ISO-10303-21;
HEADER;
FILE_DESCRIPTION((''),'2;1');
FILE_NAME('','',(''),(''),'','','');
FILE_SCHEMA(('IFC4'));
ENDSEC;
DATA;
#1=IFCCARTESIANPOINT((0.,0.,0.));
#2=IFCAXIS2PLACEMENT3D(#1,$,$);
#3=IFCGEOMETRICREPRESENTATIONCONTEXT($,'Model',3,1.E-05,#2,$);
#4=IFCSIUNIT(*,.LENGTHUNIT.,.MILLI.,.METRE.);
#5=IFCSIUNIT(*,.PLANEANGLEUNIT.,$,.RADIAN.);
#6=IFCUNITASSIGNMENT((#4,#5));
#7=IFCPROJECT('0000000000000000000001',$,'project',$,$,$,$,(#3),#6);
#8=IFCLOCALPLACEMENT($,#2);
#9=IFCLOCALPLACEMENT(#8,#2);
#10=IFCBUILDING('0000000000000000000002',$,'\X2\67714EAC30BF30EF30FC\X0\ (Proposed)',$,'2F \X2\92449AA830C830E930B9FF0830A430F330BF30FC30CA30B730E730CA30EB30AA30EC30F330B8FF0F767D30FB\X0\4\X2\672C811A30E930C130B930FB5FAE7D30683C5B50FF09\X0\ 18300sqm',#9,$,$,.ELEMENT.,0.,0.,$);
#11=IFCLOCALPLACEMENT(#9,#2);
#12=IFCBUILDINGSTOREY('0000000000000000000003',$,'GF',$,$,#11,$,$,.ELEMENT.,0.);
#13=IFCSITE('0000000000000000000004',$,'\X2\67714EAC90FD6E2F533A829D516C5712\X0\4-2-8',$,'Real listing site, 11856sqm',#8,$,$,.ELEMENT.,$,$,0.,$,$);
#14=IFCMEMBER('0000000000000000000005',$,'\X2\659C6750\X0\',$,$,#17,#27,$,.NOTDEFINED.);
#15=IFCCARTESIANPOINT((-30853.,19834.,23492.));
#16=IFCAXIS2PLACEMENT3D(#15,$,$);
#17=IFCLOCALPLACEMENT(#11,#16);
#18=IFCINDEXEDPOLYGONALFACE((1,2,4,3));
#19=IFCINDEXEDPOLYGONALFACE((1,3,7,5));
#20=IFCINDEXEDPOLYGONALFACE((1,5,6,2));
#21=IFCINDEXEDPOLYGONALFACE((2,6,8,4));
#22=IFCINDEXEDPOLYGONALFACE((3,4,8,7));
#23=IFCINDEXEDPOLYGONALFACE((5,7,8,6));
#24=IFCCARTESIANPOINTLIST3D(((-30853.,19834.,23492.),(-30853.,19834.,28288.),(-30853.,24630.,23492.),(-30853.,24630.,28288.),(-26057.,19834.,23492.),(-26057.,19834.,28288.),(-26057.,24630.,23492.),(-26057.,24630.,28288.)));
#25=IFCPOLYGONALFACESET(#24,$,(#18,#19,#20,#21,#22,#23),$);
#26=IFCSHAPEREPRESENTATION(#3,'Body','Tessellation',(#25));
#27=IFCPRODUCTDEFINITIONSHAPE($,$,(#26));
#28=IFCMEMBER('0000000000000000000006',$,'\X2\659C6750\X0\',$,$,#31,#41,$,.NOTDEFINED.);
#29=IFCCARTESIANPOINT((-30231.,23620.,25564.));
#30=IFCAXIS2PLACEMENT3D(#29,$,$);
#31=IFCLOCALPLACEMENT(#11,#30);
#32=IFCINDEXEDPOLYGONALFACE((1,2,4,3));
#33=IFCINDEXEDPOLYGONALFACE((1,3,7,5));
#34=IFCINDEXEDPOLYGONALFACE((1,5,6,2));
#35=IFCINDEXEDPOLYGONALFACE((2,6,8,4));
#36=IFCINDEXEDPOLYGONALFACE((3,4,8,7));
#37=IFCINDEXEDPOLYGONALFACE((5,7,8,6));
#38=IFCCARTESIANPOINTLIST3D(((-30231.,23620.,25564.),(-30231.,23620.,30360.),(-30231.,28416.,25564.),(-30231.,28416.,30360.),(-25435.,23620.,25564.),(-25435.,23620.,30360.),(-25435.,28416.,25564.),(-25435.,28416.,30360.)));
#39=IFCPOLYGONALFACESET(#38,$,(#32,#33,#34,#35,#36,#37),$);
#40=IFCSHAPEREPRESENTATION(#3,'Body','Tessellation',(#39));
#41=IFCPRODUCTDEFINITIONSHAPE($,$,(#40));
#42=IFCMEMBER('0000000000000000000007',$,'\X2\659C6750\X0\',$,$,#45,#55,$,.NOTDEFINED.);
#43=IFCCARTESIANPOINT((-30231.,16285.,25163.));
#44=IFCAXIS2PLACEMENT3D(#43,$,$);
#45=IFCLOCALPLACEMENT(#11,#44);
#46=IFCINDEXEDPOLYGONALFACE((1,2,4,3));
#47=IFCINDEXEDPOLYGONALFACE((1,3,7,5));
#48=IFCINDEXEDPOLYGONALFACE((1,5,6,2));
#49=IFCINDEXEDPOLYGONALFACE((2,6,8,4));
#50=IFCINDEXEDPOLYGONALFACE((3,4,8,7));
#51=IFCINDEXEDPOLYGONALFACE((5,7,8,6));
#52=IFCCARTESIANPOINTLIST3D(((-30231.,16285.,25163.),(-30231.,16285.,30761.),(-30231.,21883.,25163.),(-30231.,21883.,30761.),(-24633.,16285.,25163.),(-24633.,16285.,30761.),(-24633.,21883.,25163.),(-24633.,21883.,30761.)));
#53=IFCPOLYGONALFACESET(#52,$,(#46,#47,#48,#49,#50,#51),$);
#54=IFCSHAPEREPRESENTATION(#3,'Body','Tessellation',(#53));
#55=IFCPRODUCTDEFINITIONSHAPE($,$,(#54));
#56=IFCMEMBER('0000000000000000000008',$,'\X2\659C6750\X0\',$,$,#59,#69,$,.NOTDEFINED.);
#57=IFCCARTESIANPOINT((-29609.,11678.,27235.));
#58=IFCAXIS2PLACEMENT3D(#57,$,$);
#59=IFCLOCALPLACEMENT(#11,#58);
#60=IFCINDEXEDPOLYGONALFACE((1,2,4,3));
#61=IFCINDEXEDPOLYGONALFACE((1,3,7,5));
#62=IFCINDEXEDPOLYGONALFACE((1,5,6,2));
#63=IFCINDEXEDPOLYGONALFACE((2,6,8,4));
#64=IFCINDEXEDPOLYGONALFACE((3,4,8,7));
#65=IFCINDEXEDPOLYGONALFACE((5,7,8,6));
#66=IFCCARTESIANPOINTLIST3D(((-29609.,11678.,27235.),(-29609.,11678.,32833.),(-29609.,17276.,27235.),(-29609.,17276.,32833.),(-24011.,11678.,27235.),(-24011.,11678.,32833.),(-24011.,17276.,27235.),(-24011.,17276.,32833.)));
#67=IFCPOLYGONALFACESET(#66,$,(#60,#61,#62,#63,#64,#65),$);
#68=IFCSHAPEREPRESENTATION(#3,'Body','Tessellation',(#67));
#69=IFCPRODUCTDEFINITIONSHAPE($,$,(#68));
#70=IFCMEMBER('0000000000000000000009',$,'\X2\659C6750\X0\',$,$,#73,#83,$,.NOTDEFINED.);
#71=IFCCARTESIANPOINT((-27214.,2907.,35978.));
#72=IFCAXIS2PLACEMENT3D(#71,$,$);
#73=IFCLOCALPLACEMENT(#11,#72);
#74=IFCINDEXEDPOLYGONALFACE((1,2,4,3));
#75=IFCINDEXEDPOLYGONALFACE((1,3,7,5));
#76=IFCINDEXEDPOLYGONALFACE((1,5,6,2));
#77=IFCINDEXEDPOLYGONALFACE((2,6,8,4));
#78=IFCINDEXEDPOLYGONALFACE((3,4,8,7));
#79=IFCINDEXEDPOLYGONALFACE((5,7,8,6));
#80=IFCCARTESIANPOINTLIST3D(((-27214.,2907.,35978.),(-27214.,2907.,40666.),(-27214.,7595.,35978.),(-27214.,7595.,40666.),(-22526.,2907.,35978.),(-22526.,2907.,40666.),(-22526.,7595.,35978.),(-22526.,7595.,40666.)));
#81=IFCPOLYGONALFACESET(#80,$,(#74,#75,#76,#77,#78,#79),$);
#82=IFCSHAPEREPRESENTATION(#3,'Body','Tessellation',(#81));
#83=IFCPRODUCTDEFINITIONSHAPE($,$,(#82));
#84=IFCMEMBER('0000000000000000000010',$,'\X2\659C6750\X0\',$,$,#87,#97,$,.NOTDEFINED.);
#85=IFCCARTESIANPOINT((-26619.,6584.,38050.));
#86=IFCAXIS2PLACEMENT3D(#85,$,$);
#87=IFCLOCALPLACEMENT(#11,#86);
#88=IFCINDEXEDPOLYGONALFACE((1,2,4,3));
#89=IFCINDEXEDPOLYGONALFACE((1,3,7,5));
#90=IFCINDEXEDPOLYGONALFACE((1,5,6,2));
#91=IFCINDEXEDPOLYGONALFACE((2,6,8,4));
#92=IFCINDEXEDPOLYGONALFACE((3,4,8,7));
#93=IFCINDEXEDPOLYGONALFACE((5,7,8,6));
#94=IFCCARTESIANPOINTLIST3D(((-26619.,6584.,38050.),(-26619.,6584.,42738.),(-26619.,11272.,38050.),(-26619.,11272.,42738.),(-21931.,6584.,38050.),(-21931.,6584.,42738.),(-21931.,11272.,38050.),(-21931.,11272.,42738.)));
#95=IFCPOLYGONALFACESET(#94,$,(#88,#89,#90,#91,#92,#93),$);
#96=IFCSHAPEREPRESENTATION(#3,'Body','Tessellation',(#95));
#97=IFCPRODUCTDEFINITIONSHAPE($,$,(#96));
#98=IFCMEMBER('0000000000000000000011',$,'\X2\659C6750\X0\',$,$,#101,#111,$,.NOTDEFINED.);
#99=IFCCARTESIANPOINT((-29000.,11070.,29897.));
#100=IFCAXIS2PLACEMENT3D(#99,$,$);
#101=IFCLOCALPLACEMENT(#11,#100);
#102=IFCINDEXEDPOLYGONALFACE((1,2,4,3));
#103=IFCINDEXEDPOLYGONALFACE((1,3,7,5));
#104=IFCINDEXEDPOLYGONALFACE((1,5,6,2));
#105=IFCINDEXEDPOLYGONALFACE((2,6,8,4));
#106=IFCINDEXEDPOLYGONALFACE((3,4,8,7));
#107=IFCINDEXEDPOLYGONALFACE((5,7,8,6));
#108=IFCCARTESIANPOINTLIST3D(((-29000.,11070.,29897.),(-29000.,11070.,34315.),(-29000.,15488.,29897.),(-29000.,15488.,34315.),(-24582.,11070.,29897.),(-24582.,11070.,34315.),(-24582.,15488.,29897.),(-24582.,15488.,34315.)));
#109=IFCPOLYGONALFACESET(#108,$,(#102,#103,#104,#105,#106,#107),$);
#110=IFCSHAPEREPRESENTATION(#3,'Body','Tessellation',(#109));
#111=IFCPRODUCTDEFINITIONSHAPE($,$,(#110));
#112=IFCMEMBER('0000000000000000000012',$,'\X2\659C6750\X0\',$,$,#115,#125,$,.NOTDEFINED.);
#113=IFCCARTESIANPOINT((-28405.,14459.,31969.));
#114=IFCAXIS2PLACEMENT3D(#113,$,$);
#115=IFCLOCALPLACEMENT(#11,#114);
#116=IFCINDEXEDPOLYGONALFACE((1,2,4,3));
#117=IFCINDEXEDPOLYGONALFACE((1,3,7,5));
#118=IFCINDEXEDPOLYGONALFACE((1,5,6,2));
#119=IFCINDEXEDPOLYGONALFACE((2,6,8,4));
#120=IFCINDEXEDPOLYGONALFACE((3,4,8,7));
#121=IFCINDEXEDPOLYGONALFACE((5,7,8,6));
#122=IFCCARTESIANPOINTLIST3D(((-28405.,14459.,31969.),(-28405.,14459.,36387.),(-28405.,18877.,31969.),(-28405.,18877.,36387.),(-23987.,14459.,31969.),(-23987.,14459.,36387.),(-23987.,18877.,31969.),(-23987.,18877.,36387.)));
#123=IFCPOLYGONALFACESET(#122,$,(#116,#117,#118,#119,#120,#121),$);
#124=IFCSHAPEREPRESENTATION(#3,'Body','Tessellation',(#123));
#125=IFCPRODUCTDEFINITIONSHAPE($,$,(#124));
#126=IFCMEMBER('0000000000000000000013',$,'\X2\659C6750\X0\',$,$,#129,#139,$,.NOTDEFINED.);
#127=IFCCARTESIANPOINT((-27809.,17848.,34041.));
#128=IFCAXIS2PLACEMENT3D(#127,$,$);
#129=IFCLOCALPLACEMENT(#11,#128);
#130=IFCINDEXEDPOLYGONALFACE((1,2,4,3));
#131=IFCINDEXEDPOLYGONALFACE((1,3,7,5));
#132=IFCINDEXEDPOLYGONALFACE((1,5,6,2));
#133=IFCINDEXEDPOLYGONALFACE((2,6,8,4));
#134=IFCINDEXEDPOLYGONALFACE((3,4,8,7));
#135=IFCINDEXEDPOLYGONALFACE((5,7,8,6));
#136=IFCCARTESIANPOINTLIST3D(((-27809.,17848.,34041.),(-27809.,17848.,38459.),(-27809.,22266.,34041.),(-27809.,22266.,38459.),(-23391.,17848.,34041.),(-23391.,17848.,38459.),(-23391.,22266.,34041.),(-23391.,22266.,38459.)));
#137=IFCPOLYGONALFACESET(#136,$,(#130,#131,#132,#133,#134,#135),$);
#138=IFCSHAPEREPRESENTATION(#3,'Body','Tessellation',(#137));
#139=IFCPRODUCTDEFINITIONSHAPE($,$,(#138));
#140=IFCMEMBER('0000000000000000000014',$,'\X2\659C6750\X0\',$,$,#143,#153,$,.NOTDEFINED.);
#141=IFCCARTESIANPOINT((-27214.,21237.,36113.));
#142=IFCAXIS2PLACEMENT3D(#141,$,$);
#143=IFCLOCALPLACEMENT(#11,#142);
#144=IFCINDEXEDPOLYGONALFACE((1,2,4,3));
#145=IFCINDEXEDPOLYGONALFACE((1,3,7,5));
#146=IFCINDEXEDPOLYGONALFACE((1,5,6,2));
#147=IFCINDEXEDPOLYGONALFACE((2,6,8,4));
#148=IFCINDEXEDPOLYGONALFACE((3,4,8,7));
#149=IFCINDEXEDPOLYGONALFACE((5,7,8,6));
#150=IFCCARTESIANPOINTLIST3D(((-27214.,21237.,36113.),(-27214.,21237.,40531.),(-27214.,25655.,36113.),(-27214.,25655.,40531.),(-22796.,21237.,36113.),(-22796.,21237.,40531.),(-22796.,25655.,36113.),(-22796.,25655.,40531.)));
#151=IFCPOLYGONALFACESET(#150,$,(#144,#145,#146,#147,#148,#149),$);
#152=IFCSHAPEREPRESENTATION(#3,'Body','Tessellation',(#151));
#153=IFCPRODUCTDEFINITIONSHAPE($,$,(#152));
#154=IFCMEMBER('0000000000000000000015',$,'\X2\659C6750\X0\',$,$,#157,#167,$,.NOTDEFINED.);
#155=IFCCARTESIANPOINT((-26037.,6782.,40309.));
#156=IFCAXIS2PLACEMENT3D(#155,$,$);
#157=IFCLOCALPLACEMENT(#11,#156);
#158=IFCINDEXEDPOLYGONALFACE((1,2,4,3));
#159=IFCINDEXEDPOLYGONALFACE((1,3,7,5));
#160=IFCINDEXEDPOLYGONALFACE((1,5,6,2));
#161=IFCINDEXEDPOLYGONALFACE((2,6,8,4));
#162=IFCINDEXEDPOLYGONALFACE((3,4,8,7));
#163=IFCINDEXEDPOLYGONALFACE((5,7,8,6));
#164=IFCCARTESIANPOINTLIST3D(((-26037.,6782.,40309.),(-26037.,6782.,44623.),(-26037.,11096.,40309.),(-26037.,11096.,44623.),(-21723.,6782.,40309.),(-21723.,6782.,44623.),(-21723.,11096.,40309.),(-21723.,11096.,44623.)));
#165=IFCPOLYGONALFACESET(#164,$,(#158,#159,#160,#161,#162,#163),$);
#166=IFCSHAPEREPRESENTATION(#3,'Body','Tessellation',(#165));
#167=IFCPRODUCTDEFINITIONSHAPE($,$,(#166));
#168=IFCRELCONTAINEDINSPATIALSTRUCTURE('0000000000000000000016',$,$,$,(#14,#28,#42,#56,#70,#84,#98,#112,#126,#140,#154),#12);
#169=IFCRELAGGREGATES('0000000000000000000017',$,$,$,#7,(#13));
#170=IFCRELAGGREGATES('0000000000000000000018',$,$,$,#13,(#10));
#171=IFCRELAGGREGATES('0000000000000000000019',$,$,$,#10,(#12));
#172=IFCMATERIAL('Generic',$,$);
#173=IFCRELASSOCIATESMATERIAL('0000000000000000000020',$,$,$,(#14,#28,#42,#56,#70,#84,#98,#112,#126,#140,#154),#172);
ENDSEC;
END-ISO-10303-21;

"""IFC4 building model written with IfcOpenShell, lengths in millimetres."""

from ifc_helpers import new_model, si_unit, frame, frame_2d, origin, place, context, project, spatial, rectangle, extrude, material, element, save


model = new_model("IFC4")

# Units and contexts
model_context = context("Model", 3, precision=1e-05, world=origin())
ifc_project = project(units=[si_unit("LENGTHUNIT", "METRE", prefix="MILLI"), si_unit("PLANEANGLEUNIT", "RADIAN")], contexts=[model_context])

# Site, building, storey
site_placement = place(None, origin())
site = spatial("IfcSite", under=ifc_project, at=site_placement, Name="東京都港区芝公園4-2-8", ObjectType="Real listing site, 11856sqm", CompositionType="ELEMENT", RefElevation=0.0)
building_placement = place(site_placement, origin())
building = spatial("IfcBuilding", under=site, at=building_placement, Name="東京タワー (Proposed)", ObjectType="2F 鉄骨トラス（インターナショナルオレンジ／白・4本脚ラチス・微細格子） 18300sqm", CompositionType="ELEMENT", ElevationOfRefHeight=0.0, ElevationOfTerrain=0.0)
storey_placement = place(building_placement, origin())
storey = spatial("IfcBuildingStorey", under=building, at=storey_placement, Name="GF", CompositionType="ELEMENT", Elevation=0.0)

# Shared definitions
ifc_material = material(Name="Generic")

# Members
member_1_placement = place(storey_placement, frame((-30853.0, 19834.0, 23492.0)))
element("IfcMember", 1, at=member_1_placement, inside=storey, material=ifc_material, Name="斜材", PredefinedType="NOTDEFINED", context=model_context, shape_type="SweptSolid", body=[
    extrude(rectangle(XDim=4796.0, YDim=4796.0, at=frame_2d((2398.0, 2398.0))), frame((-30853.0, 19834.0, 23492.0)), (0.0, 0.0, 1.0), 4796.0),
])
member_2_placement = place(storey_placement, frame((-30231.0, 23620.0, 25564.0)))
element("IfcMember", 2, at=member_2_placement, inside=storey, material=ifc_material, Name="斜材", PredefinedType="NOTDEFINED", context=model_context, shape_type="SweptSolid", body=[
    extrude(rectangle(XDim=4796.0, YDim=4796.0, at=frame_2d((2398.0, 2398.0))), frame((-30231.0, 23620.0, 25564.0)), (0.0, 0.0, 1.0), 4796.0),
])
member_3_placement = place(storey_placement, frame((-30231.0, 16285.0, 25163.0)))
element("IfcMember", 3, at=member_3_placement, inside=storey, material=ifc_material, Name="斜材", PredefinedType="NOTDEFINED", context=model_context, shape_type="SweptSolid", body=[
    extrude(rectangle(XDim=5598.0, YDim=5598.0, at=frame_2d((2799.0, 2799.0))), frame((-30231.0, 16285.0, 25163.0)), (0.0, 0.0, 1.0), 5598.0),
])
member_4_placement = place(storey_placement, frame((-29609.0, 11678.0, 27235.0)))
element("IfcMember", 4, at=member_4_placement, inside=storey, material=ifc_material, Name="斜材", PredefinedType="NOTDEFINED", context=model_context, shape_type="SweptSolid", body=[
    extrude(rectangle(XDim=5598.0, YDim=5598.0, at=frame_2d((2799.0, 2799.0))), frame((-29609.0, 11678.0, 27235.0)), (0.0, 0.0, 1.0), 5598.0),
])
member_5_placement = place(storey_placement, frame((-27214.0, 2907.0, 35978.0)))
element("IfcMember", 5, at=member_5_placement, inside=storey, material=ifc_material, Name="斜材", PredefinedType="NOTDEFINED", context=model_context, shape_type="SweptSolid", body=[
    extrude(rectangle(XDim=4688.0, YDim=4688.0, at=frame_2d((2344.0, 2344.0))), frame((-27214.0, 2907.0, 35978.0)), (0.0, 0.0, 1.0), 4688.0),
])
member_6_placement = place(storey_placement, frame((-26619.0, 6584.0, 38050.0)))
element("IfcMember", 6, at=member_6_placement, inside=storey, material=ifc_material, Name="斜材", PredefinedType="NOTDEFINED", context=model_context, shape_type="SweptSolid", body=[
    extrude(rectangle(XDim=4688.0, YDim=4688.0, at=frame_2d((2344.0, 2344.0))), frame((-26619.0, 6584.0, 38050.0)), (0.0, 0.0, 1.0), 4688.0),
])
member_7_placement = place(storey_placement, frame((-29000.0, 11070.0, 29897.0)))
element("IfcMember", 7, at=member_7_placement, inside=storey, material=ifc_material, Name="斜材", PredefinedType="NOTDEFINED", context=model_context, shape_type="SweptSolid", body=[
    extrude(rectangle(XDim=4418.0, YDim=4418.0, at=frame_2d((2209.0, 2209.0))), frame((-29000.0, 11070.0, 29897.0)), (0.0, 0.0, 1.0), 4418.0),
])
member_8_placement = place(storey_placement, frame((-28405.0, 14459.0, 31969.0)))
element("IfcMember", 8, at=member_8_placement, inside=storey, material=ifc_material, Name="斜材", PredefinedType="NOTDEFINED", context=model_context, shape_type="SweptSolid", body=[
    extrude(rectangle(XDim=4418.0, YDim=4418.0, at=frame_2d((2209.0, 2209.0))), frame((-28405.0, 14459.0, 31969.0)), (0.0, 0.0, 1.0), 4418.0),
])
member_9_placement = place(storey_placement, frame((-27809.0, 17848.0, 34041.0)))
element("IfcMember", 9, at=member_9_placement, inside=storey, material=ifc_material, Name="斜材", PredefinedType="NOTDEFINED", context=model_context, shape_type="SweptSolid", body=[
    extrude(rectangle(XDim=4418.0, YDim=4418.0, at=frame_2d((2209.0, 2209.0))), frame((-27809.0, 17848.0, 34041.0)), (0.0, 0.0, 1.0), 4418.0),
])
member_10_placement = place(storey_placement, frame((-27214.0, 21237.0, 36113.0)))
element("IfcMember", 10, at=member_10_placement, inside=storey, material=ifc_material, Name="斜材", PredefinedType="NOTDEFINED", context=model_context, shape_type="SweptSolid", body=[
    extrude(rectangle(XDim=4418.0, YDim=4418.0, at=frame_2d((2209.0, 2209.0))), frame((-27214.0, 21237.0, 36113.0)), (0.0, 0.0, 1.0), 4418.0),
])
member_11_placement = place(storey_placement, frame((-26037.0, 6782.0, 40309.0)))
element("IfcMember", 11, at=member_11_placement, inside=storey, material=ifc_material, Name="斜材", PredefinedType="NOTDEFINED", context=model_context, shape_type="SweptSolid", body=[
    extrude(rectangle(XDim=4314.0, YDim=4314.0, at=frame_2d((2157.0, 2157.0))), frame((-26037.0, 6782.0, 40309.0)), (0.0, 0.0, 1.0), 4314.0),
])

save(model, "model.ifc")
